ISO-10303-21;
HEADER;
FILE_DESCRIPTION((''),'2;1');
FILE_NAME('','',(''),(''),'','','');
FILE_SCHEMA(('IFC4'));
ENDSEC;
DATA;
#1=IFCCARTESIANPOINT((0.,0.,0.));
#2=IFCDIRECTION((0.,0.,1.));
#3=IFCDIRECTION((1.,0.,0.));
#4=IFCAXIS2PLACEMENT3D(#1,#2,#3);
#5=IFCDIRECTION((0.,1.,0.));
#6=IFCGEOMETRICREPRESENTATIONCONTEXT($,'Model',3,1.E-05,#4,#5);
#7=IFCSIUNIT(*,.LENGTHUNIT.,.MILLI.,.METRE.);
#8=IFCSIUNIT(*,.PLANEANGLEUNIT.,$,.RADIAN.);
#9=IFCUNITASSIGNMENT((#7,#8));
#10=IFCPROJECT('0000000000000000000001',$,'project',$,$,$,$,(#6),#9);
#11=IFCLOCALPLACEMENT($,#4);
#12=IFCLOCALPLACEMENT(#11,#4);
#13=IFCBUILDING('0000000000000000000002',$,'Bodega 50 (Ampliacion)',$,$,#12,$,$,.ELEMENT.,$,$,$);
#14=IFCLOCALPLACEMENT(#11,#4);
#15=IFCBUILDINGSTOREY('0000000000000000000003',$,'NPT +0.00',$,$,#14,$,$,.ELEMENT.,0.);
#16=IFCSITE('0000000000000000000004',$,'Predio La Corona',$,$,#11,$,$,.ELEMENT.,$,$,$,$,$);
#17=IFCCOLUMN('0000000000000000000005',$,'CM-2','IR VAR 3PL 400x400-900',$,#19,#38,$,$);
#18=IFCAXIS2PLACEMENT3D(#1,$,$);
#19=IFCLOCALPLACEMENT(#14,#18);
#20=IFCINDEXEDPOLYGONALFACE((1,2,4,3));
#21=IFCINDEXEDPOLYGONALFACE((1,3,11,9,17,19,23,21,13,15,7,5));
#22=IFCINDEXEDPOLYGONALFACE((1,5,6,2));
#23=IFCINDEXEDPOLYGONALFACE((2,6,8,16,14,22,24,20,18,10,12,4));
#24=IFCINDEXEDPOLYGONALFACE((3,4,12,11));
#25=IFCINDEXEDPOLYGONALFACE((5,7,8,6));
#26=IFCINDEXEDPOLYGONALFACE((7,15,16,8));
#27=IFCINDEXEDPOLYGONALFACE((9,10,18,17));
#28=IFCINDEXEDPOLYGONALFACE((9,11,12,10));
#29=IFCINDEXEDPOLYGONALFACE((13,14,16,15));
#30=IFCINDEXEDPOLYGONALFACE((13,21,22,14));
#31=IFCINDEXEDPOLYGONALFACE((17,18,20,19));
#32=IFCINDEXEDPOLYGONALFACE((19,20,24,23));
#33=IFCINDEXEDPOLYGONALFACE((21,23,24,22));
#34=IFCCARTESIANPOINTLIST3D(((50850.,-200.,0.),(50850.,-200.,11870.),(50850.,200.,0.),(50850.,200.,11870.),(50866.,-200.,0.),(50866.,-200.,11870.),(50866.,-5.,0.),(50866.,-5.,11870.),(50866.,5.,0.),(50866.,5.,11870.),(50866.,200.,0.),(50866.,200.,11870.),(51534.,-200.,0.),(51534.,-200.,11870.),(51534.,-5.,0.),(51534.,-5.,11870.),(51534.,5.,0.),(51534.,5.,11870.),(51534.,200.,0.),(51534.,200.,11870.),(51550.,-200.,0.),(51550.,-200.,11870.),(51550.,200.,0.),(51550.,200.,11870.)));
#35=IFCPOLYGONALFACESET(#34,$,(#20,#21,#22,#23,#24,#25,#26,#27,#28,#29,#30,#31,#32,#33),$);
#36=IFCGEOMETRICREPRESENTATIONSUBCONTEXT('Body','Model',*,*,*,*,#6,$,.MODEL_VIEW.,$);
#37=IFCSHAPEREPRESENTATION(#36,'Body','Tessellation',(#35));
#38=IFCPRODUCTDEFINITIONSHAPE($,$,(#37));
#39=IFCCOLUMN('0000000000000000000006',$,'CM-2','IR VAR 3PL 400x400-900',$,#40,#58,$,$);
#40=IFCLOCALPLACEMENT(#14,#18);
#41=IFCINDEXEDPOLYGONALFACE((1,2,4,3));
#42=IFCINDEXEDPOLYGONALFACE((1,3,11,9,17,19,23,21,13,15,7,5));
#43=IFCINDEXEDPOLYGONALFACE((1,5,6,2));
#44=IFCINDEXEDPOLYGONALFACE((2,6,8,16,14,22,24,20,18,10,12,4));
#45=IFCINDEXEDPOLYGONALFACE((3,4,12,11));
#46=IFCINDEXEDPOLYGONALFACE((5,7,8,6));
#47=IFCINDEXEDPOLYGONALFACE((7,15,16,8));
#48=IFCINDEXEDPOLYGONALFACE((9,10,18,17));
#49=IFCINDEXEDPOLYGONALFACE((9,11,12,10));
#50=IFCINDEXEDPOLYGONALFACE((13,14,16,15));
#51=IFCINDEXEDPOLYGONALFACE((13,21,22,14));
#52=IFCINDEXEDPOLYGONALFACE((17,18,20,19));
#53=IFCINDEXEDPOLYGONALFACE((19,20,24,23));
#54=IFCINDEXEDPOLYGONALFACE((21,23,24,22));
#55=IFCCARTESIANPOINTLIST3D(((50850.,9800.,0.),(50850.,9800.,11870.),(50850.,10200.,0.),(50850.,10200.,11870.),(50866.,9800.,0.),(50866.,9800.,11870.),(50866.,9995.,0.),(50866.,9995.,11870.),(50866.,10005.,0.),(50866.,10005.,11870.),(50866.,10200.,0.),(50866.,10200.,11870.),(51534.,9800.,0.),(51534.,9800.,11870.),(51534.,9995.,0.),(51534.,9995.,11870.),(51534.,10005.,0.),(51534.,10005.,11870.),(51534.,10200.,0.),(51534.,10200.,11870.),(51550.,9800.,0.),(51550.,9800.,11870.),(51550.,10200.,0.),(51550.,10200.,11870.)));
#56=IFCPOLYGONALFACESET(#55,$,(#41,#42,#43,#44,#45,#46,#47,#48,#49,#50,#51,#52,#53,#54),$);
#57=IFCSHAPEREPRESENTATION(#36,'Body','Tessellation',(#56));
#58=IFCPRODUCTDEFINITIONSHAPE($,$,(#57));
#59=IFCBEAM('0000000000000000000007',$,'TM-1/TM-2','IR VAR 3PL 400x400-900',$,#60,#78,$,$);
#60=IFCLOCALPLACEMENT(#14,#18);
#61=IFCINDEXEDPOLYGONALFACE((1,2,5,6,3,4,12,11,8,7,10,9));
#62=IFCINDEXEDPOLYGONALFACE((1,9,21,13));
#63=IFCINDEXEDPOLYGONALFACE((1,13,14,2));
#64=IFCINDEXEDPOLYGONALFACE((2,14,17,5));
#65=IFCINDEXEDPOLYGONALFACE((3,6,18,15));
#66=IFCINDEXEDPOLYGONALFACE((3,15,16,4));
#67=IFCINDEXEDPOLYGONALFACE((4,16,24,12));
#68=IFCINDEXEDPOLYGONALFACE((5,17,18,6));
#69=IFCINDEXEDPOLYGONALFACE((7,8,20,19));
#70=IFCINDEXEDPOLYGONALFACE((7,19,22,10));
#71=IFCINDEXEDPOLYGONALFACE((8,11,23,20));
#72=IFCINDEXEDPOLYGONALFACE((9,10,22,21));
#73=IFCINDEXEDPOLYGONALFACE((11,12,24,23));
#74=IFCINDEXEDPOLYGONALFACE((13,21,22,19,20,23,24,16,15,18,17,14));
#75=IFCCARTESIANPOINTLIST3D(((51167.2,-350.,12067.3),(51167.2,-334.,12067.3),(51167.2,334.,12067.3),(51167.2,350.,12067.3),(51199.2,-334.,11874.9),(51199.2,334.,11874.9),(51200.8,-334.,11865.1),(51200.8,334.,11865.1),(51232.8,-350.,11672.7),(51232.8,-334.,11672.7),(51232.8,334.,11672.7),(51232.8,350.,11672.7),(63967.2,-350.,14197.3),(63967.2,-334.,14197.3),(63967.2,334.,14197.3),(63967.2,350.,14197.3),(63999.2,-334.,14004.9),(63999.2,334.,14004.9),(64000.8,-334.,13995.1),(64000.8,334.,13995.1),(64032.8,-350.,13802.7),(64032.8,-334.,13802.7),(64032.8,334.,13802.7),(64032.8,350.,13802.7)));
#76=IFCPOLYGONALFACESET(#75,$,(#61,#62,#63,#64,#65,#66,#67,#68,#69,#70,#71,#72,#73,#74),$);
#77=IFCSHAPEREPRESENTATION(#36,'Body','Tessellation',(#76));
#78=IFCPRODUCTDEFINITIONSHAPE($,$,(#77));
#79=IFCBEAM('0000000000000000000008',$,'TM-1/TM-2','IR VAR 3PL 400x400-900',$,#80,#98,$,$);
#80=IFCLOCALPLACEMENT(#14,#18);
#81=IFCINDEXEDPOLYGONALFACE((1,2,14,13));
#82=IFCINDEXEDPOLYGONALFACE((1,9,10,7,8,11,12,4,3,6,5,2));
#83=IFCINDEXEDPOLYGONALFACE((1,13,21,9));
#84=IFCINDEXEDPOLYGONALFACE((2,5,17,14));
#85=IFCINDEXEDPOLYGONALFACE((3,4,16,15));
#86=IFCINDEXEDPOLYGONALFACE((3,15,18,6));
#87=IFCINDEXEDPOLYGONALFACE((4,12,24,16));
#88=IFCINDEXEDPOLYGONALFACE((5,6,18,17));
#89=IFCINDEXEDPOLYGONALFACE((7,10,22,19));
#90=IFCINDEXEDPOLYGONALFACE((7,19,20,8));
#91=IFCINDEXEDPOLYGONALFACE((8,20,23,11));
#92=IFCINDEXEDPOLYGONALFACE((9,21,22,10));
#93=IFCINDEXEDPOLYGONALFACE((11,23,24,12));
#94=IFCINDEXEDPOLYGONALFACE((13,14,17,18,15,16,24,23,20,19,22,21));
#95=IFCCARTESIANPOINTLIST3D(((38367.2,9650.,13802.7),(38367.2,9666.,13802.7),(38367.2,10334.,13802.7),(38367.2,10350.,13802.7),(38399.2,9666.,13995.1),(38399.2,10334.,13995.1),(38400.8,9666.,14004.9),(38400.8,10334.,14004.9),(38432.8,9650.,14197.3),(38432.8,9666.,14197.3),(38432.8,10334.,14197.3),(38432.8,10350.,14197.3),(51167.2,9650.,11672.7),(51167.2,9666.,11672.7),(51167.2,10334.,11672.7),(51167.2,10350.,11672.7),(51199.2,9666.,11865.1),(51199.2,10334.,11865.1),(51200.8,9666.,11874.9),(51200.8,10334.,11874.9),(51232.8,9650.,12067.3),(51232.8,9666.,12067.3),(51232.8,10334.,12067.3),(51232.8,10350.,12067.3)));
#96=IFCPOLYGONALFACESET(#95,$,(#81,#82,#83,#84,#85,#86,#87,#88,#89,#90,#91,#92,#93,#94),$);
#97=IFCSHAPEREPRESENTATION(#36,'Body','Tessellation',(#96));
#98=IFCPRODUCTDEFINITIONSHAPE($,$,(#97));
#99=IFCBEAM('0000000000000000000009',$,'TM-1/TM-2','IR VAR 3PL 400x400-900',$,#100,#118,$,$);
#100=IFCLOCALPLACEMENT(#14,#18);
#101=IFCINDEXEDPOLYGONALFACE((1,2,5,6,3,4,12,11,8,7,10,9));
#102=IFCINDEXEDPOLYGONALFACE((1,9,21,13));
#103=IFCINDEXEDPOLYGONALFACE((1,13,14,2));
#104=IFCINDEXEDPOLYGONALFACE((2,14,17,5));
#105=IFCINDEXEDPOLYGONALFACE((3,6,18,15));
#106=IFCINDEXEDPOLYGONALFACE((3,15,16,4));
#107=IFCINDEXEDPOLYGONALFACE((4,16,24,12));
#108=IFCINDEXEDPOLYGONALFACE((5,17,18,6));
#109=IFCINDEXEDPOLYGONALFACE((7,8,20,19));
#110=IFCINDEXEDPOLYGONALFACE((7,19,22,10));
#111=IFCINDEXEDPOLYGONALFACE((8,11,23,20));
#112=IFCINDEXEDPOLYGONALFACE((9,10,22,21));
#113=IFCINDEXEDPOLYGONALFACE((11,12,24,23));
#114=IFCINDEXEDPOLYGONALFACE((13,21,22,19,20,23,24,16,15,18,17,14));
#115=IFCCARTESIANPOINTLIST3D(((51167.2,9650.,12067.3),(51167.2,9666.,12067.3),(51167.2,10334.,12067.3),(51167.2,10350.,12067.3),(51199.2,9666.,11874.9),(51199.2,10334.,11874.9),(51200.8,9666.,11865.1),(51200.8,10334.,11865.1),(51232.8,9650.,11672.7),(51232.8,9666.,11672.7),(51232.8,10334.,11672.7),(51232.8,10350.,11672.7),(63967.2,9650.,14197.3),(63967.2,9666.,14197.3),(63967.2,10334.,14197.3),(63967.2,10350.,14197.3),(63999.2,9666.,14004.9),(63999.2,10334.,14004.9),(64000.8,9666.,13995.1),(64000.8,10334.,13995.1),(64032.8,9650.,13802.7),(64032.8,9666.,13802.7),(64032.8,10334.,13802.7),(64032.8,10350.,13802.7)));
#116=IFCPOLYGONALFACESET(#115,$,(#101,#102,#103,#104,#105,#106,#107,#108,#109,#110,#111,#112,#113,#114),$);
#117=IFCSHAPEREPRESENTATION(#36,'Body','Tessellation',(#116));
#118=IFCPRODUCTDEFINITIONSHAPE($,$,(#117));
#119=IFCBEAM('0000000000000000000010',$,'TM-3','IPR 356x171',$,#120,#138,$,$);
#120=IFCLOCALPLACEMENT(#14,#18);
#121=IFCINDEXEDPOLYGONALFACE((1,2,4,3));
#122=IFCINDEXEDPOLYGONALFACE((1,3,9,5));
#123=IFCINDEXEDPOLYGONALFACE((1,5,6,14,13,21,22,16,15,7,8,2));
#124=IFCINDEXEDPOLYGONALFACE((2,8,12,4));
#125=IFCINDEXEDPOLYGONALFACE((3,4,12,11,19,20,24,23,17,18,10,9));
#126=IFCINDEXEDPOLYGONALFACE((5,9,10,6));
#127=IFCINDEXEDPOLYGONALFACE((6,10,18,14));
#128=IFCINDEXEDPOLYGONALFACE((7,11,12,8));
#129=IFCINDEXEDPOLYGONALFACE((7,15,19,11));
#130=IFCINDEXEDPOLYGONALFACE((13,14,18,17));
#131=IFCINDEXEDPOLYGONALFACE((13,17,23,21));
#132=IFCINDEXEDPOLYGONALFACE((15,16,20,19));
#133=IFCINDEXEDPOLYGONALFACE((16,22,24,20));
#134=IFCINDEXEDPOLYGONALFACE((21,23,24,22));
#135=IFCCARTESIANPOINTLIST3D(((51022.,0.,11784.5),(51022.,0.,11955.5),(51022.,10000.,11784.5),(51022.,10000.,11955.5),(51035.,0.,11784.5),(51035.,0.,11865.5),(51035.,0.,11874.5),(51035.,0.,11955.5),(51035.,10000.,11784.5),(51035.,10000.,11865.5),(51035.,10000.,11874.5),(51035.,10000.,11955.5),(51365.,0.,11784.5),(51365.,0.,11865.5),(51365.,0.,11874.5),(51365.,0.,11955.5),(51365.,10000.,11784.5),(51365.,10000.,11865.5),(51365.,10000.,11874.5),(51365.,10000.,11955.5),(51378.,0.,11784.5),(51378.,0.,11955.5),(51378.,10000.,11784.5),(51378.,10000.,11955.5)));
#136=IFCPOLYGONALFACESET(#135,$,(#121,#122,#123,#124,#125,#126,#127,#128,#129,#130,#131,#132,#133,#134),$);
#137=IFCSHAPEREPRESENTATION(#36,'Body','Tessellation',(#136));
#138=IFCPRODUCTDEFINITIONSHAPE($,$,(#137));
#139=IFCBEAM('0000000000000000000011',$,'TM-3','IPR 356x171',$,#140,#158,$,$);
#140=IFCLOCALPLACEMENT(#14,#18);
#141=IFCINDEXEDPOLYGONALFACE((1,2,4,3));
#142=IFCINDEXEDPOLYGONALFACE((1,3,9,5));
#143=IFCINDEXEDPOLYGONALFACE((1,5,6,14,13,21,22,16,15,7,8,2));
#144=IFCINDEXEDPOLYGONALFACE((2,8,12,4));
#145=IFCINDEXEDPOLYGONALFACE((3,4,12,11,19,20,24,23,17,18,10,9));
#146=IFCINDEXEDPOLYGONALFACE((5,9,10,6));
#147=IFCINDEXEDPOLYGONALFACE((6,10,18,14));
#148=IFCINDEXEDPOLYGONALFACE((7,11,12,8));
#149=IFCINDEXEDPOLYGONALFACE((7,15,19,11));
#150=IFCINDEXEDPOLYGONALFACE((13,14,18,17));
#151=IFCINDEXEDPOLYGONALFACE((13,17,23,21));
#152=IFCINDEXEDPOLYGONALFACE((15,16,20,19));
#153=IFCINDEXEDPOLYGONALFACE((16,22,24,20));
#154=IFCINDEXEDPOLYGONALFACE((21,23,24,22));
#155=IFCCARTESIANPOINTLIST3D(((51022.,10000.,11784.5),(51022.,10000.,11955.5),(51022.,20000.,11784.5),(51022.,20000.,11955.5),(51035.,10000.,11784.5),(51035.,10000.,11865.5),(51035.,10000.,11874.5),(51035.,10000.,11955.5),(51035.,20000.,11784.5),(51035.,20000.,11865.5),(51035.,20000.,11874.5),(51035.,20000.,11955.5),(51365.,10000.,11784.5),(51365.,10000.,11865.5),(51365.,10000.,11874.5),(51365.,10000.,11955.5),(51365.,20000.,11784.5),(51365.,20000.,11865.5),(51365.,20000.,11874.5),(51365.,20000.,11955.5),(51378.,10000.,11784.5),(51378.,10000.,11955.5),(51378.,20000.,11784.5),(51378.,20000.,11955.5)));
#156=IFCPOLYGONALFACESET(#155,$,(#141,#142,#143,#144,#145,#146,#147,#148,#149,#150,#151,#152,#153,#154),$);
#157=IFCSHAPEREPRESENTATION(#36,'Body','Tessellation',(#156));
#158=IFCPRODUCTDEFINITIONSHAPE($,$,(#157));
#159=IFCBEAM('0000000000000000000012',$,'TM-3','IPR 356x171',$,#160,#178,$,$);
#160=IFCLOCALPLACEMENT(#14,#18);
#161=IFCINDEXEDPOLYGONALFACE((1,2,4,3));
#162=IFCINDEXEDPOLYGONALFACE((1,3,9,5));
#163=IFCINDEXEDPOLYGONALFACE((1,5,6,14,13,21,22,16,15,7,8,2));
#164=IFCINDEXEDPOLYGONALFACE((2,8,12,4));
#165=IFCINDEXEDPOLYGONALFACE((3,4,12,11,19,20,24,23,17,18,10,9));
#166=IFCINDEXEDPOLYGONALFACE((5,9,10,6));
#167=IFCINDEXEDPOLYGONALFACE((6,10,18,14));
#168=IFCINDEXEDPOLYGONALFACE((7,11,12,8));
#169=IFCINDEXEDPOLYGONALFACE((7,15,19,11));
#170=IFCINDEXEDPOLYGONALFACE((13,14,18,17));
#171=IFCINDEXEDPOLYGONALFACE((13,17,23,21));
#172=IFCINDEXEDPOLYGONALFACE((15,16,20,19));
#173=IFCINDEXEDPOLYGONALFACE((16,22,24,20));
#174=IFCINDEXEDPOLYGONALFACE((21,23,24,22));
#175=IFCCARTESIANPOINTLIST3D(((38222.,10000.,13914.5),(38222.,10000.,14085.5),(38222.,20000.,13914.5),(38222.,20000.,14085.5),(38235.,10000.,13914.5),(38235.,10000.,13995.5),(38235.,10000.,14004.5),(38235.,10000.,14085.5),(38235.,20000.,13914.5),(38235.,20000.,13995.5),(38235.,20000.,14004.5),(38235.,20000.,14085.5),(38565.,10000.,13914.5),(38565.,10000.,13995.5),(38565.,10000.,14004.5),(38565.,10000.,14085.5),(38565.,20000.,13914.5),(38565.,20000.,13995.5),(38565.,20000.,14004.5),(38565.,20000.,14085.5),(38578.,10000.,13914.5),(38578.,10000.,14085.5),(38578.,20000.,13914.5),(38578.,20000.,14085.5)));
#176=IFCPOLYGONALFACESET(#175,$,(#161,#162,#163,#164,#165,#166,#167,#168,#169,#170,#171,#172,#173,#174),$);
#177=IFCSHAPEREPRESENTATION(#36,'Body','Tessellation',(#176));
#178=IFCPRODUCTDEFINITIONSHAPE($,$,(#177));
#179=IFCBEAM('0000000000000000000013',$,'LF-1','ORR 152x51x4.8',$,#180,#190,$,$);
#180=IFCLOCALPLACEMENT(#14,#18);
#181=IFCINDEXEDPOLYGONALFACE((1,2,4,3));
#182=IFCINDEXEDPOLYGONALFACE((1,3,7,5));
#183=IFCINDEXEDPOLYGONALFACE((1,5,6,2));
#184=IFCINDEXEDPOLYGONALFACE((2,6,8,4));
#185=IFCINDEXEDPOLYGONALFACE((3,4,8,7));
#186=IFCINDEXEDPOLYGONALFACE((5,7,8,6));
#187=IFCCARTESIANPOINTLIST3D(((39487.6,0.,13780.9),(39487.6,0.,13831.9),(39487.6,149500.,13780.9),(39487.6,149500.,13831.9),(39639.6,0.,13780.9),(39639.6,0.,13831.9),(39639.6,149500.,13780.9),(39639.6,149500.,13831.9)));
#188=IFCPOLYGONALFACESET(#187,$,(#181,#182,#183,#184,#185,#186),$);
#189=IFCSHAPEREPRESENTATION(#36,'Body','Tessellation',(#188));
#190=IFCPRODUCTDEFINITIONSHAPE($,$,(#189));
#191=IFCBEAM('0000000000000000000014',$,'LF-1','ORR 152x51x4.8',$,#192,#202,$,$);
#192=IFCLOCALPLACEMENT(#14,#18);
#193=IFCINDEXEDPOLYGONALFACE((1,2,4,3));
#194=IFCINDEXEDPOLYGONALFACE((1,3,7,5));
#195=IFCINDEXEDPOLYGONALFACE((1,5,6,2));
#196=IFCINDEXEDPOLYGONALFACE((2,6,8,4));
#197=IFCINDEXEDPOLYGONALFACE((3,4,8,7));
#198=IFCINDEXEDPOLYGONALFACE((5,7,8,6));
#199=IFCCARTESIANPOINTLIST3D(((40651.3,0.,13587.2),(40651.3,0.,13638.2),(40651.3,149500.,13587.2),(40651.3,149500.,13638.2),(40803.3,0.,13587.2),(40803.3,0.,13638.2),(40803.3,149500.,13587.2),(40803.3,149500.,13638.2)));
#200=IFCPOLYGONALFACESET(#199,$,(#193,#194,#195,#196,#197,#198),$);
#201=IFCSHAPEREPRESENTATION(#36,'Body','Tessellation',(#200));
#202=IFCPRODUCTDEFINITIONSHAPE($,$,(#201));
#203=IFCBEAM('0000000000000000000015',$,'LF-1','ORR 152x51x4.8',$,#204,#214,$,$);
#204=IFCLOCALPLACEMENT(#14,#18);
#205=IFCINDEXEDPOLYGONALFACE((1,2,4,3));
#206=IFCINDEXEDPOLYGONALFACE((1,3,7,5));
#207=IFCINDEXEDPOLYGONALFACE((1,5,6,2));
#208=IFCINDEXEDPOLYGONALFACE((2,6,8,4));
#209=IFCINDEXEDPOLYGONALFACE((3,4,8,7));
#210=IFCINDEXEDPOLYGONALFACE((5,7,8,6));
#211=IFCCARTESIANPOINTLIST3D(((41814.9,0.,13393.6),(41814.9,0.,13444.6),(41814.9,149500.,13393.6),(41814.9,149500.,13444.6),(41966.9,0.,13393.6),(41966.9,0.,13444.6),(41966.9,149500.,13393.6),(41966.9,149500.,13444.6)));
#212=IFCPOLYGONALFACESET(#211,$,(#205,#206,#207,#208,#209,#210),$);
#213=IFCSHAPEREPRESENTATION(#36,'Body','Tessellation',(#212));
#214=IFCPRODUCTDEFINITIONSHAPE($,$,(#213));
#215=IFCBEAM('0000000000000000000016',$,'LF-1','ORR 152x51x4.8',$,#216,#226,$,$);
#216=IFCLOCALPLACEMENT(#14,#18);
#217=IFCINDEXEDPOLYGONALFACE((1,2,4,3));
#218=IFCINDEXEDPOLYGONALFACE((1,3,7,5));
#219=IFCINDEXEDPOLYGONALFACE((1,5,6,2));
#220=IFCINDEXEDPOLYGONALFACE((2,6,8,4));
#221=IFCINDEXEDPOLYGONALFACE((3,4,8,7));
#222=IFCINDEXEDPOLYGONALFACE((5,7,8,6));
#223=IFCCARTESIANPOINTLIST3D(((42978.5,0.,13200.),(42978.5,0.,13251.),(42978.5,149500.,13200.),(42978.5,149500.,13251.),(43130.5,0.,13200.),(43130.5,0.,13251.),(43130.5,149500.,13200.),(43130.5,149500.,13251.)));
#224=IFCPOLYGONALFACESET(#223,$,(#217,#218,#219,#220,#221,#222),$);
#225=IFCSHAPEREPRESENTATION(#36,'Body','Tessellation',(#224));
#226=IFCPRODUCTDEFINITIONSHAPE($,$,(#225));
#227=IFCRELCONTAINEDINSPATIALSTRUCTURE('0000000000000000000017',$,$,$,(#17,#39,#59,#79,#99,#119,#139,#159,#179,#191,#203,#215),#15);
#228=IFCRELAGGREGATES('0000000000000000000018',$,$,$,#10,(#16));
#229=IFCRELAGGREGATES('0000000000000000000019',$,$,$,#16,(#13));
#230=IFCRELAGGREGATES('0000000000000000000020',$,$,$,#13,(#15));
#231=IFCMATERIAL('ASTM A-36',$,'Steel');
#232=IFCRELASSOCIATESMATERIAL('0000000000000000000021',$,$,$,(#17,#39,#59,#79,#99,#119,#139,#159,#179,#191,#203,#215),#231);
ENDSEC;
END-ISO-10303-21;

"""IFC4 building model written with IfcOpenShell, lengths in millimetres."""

from ifc_helpers import new_model, si_unit, direction, frame, origin_with_axes, origin_2d, place, context, subcontext, project, spatial, rectangle, i_section, extrude, material, element, save


model = new_model("IFC4")

# Units and contexts
model_context = context("Model", 3, precision=1e-05, world=origin_with_axes(), true_north=direction((0.0, 1.0, 0.0)))
body_context = subcontext(model_context, "Body", "Model", "MODEL_VIEW")
ifc_project = project(units=[si_unit("LENGTHUNIT", "METRE", prefix="MILLI"), si_unit("PLANEANGLEUNIT", "RADIAN")], contexts=[model_context])

# Site, building, storey
site_placement = place(None, origin_with_axes())
site = spatial("IfcSite", under=ifc_project, at=site_placement, Name="Predio La Corona", CompositionType="ELEMENT")
building_placement = place(site_placement, origin_with_axes())
building = spatial("IfcBuilding", under=site, at=building_placement, Name="Bodega 50 (Ampliacion)", CompositionType="ELEMENT")
storey_placement = place(site_placement, origin_with_axes())
storey = spatial("IfcBuildingStorey", under=building, at=storey_placement, Name="NPT +0.00", CompositionType="ELEMENT", Elevation=0.0)

# Columns
ifc_material = material(Name="ASTM A-36", Category="Steel")
for number, where, z_axis, x_axis, name in (
    (1, (51200.0, 0.0, 0.0), (0.0, 0.0, 1.0), (0.0, -1.0, 0.0), "CM-2"),
    (2, (51200.0, 10000.0, 0.0), (0.0, 0.0, 1.0), (0.0, -1.0, 0.0), "CM-2"),
):
    element("IfcColumn", number, at=place(storey_placement, frame(where, z_axis=z_axis, x_axis=x_axis)), inside=storey, material=ifc_material, Name=name, Description="IR VAR 3PL 400x400-900", context=body_context, shape_type="SweptSolid", body=[
        extrude(i_section(OverallWidth=400.0, OverallDepth=700.0, WebThickness=10.0, FlangeThickness=16.0, at=origin_2d()), origin_with_axes(), (0.0, 0.0, 1.0), 11870.0),
    ])

# Beams
for number, where, z_axis, x_axis, name in (
    (3, (51200.0, 0.0, 11870.0), (0.986436, 0.0, 0.164149), (0.164149, 0.0, -0.986436), "TM-1/TM-2"),
    (4, (38400.0, 10000.0, 14000.0), (0.986436, 0.0, -0.164149), (-0.164149, 0.0, -0.986436), "TM-1/TM-2"),
    (5, (51200.0, 10000.0, 11870.0), (0.986436, 0.0, 0.164149), (0.164149, 0.0, -0.986436), "TM-1/TM-2"),
):
    element("IfcBeam", number, at=place(storey_placement, frame(where, z_axis=z_axis, x_axis=x_axis)), inside=storey, material=ifc_material, Name=name, Description="IR VAR 3PL 400x400-900", context=body_context, shape_type="SweptSolid", body=[
        extrude(i_section(OverallWidth=400.0, OverallDepth=700.0, WebThickness=10.0, FlangeThickness=16.0, at=origin_2d()), origin_with_axes(), (0.0, 0.0, 1.0), 12976.0),
    ])
for number, where, z_axis, x_axis, name in (
    (6, (51200.0, 0.0, 11870.0), (0.0, 1.0, 0.0), (0.0, 0.0, 1.0), "TM-3"),
    (7, (51200.0, 10000.0, 11870.0), (0.0, 1.0, 0.0), (0.0, 0.0, 1.0), "TM-3"),
    (8, (38400.0, 10000.0, 14000.0), (0.0, 1.0, 0.0), (0.0, 0.0, 1.0), "TM-3"),
):
    element("IfcBeam", number, at=place(storey_placement, frame(where, z_axis=z_axis, x_axis=x_axis)), inside=storey, material=ifc_material, Name=name, Description="IPR 356x171", context=body_context, shape_type="SweptSolid", body=[
        extrude(i_section(OverallWidth=171.0, OverallDepth=356.0, WebThickness=9.0, FlangeThickness=13.0, at=origin_2d()), origin_with_axes(), (0.0, 0.0, 1.0), 10000.0),
    ])
for number, where, z_axis, x_axis, name in (
    (9, (39563.6, 0.0, 13806.4), (0.0, 1.0, 0.0), (0.0, 0.0, 1.0), "LF-1"),
    (10, (40727.3, 0.0, 13612.7), (0.0, 1.0, 0.0), (0.0, 0.0, 1.0), "LF-1"),
    (11, (41890.9, 0.0, 13419.1), (0.0, 1.0, 0.0), (0.0, 0.0, 1.0), "LF-1"),
    (12, (43054.5, 0.0, 13225.5), (0.0, 1.0, 0.0), (0.0, 0.0, 1.0), "LF-1"),
):
    element("IfcBeam", number, at=place(storey_placement, frame(where, z_axis=z_axis, x_axis=x_axis)), inside=storey, material=ifc_material, Name=name, Description="ORR 152x51x4.8", context=body_context, shape_type="SweptSolid", body=[
        extrude(rectangle(XDim=51.0, YDim=152.0, at=origin_2d()), origin_with_axes(), (0.0, 0.0, 1.0), 149500.0),
    ])

save(model, "model.ifc")
